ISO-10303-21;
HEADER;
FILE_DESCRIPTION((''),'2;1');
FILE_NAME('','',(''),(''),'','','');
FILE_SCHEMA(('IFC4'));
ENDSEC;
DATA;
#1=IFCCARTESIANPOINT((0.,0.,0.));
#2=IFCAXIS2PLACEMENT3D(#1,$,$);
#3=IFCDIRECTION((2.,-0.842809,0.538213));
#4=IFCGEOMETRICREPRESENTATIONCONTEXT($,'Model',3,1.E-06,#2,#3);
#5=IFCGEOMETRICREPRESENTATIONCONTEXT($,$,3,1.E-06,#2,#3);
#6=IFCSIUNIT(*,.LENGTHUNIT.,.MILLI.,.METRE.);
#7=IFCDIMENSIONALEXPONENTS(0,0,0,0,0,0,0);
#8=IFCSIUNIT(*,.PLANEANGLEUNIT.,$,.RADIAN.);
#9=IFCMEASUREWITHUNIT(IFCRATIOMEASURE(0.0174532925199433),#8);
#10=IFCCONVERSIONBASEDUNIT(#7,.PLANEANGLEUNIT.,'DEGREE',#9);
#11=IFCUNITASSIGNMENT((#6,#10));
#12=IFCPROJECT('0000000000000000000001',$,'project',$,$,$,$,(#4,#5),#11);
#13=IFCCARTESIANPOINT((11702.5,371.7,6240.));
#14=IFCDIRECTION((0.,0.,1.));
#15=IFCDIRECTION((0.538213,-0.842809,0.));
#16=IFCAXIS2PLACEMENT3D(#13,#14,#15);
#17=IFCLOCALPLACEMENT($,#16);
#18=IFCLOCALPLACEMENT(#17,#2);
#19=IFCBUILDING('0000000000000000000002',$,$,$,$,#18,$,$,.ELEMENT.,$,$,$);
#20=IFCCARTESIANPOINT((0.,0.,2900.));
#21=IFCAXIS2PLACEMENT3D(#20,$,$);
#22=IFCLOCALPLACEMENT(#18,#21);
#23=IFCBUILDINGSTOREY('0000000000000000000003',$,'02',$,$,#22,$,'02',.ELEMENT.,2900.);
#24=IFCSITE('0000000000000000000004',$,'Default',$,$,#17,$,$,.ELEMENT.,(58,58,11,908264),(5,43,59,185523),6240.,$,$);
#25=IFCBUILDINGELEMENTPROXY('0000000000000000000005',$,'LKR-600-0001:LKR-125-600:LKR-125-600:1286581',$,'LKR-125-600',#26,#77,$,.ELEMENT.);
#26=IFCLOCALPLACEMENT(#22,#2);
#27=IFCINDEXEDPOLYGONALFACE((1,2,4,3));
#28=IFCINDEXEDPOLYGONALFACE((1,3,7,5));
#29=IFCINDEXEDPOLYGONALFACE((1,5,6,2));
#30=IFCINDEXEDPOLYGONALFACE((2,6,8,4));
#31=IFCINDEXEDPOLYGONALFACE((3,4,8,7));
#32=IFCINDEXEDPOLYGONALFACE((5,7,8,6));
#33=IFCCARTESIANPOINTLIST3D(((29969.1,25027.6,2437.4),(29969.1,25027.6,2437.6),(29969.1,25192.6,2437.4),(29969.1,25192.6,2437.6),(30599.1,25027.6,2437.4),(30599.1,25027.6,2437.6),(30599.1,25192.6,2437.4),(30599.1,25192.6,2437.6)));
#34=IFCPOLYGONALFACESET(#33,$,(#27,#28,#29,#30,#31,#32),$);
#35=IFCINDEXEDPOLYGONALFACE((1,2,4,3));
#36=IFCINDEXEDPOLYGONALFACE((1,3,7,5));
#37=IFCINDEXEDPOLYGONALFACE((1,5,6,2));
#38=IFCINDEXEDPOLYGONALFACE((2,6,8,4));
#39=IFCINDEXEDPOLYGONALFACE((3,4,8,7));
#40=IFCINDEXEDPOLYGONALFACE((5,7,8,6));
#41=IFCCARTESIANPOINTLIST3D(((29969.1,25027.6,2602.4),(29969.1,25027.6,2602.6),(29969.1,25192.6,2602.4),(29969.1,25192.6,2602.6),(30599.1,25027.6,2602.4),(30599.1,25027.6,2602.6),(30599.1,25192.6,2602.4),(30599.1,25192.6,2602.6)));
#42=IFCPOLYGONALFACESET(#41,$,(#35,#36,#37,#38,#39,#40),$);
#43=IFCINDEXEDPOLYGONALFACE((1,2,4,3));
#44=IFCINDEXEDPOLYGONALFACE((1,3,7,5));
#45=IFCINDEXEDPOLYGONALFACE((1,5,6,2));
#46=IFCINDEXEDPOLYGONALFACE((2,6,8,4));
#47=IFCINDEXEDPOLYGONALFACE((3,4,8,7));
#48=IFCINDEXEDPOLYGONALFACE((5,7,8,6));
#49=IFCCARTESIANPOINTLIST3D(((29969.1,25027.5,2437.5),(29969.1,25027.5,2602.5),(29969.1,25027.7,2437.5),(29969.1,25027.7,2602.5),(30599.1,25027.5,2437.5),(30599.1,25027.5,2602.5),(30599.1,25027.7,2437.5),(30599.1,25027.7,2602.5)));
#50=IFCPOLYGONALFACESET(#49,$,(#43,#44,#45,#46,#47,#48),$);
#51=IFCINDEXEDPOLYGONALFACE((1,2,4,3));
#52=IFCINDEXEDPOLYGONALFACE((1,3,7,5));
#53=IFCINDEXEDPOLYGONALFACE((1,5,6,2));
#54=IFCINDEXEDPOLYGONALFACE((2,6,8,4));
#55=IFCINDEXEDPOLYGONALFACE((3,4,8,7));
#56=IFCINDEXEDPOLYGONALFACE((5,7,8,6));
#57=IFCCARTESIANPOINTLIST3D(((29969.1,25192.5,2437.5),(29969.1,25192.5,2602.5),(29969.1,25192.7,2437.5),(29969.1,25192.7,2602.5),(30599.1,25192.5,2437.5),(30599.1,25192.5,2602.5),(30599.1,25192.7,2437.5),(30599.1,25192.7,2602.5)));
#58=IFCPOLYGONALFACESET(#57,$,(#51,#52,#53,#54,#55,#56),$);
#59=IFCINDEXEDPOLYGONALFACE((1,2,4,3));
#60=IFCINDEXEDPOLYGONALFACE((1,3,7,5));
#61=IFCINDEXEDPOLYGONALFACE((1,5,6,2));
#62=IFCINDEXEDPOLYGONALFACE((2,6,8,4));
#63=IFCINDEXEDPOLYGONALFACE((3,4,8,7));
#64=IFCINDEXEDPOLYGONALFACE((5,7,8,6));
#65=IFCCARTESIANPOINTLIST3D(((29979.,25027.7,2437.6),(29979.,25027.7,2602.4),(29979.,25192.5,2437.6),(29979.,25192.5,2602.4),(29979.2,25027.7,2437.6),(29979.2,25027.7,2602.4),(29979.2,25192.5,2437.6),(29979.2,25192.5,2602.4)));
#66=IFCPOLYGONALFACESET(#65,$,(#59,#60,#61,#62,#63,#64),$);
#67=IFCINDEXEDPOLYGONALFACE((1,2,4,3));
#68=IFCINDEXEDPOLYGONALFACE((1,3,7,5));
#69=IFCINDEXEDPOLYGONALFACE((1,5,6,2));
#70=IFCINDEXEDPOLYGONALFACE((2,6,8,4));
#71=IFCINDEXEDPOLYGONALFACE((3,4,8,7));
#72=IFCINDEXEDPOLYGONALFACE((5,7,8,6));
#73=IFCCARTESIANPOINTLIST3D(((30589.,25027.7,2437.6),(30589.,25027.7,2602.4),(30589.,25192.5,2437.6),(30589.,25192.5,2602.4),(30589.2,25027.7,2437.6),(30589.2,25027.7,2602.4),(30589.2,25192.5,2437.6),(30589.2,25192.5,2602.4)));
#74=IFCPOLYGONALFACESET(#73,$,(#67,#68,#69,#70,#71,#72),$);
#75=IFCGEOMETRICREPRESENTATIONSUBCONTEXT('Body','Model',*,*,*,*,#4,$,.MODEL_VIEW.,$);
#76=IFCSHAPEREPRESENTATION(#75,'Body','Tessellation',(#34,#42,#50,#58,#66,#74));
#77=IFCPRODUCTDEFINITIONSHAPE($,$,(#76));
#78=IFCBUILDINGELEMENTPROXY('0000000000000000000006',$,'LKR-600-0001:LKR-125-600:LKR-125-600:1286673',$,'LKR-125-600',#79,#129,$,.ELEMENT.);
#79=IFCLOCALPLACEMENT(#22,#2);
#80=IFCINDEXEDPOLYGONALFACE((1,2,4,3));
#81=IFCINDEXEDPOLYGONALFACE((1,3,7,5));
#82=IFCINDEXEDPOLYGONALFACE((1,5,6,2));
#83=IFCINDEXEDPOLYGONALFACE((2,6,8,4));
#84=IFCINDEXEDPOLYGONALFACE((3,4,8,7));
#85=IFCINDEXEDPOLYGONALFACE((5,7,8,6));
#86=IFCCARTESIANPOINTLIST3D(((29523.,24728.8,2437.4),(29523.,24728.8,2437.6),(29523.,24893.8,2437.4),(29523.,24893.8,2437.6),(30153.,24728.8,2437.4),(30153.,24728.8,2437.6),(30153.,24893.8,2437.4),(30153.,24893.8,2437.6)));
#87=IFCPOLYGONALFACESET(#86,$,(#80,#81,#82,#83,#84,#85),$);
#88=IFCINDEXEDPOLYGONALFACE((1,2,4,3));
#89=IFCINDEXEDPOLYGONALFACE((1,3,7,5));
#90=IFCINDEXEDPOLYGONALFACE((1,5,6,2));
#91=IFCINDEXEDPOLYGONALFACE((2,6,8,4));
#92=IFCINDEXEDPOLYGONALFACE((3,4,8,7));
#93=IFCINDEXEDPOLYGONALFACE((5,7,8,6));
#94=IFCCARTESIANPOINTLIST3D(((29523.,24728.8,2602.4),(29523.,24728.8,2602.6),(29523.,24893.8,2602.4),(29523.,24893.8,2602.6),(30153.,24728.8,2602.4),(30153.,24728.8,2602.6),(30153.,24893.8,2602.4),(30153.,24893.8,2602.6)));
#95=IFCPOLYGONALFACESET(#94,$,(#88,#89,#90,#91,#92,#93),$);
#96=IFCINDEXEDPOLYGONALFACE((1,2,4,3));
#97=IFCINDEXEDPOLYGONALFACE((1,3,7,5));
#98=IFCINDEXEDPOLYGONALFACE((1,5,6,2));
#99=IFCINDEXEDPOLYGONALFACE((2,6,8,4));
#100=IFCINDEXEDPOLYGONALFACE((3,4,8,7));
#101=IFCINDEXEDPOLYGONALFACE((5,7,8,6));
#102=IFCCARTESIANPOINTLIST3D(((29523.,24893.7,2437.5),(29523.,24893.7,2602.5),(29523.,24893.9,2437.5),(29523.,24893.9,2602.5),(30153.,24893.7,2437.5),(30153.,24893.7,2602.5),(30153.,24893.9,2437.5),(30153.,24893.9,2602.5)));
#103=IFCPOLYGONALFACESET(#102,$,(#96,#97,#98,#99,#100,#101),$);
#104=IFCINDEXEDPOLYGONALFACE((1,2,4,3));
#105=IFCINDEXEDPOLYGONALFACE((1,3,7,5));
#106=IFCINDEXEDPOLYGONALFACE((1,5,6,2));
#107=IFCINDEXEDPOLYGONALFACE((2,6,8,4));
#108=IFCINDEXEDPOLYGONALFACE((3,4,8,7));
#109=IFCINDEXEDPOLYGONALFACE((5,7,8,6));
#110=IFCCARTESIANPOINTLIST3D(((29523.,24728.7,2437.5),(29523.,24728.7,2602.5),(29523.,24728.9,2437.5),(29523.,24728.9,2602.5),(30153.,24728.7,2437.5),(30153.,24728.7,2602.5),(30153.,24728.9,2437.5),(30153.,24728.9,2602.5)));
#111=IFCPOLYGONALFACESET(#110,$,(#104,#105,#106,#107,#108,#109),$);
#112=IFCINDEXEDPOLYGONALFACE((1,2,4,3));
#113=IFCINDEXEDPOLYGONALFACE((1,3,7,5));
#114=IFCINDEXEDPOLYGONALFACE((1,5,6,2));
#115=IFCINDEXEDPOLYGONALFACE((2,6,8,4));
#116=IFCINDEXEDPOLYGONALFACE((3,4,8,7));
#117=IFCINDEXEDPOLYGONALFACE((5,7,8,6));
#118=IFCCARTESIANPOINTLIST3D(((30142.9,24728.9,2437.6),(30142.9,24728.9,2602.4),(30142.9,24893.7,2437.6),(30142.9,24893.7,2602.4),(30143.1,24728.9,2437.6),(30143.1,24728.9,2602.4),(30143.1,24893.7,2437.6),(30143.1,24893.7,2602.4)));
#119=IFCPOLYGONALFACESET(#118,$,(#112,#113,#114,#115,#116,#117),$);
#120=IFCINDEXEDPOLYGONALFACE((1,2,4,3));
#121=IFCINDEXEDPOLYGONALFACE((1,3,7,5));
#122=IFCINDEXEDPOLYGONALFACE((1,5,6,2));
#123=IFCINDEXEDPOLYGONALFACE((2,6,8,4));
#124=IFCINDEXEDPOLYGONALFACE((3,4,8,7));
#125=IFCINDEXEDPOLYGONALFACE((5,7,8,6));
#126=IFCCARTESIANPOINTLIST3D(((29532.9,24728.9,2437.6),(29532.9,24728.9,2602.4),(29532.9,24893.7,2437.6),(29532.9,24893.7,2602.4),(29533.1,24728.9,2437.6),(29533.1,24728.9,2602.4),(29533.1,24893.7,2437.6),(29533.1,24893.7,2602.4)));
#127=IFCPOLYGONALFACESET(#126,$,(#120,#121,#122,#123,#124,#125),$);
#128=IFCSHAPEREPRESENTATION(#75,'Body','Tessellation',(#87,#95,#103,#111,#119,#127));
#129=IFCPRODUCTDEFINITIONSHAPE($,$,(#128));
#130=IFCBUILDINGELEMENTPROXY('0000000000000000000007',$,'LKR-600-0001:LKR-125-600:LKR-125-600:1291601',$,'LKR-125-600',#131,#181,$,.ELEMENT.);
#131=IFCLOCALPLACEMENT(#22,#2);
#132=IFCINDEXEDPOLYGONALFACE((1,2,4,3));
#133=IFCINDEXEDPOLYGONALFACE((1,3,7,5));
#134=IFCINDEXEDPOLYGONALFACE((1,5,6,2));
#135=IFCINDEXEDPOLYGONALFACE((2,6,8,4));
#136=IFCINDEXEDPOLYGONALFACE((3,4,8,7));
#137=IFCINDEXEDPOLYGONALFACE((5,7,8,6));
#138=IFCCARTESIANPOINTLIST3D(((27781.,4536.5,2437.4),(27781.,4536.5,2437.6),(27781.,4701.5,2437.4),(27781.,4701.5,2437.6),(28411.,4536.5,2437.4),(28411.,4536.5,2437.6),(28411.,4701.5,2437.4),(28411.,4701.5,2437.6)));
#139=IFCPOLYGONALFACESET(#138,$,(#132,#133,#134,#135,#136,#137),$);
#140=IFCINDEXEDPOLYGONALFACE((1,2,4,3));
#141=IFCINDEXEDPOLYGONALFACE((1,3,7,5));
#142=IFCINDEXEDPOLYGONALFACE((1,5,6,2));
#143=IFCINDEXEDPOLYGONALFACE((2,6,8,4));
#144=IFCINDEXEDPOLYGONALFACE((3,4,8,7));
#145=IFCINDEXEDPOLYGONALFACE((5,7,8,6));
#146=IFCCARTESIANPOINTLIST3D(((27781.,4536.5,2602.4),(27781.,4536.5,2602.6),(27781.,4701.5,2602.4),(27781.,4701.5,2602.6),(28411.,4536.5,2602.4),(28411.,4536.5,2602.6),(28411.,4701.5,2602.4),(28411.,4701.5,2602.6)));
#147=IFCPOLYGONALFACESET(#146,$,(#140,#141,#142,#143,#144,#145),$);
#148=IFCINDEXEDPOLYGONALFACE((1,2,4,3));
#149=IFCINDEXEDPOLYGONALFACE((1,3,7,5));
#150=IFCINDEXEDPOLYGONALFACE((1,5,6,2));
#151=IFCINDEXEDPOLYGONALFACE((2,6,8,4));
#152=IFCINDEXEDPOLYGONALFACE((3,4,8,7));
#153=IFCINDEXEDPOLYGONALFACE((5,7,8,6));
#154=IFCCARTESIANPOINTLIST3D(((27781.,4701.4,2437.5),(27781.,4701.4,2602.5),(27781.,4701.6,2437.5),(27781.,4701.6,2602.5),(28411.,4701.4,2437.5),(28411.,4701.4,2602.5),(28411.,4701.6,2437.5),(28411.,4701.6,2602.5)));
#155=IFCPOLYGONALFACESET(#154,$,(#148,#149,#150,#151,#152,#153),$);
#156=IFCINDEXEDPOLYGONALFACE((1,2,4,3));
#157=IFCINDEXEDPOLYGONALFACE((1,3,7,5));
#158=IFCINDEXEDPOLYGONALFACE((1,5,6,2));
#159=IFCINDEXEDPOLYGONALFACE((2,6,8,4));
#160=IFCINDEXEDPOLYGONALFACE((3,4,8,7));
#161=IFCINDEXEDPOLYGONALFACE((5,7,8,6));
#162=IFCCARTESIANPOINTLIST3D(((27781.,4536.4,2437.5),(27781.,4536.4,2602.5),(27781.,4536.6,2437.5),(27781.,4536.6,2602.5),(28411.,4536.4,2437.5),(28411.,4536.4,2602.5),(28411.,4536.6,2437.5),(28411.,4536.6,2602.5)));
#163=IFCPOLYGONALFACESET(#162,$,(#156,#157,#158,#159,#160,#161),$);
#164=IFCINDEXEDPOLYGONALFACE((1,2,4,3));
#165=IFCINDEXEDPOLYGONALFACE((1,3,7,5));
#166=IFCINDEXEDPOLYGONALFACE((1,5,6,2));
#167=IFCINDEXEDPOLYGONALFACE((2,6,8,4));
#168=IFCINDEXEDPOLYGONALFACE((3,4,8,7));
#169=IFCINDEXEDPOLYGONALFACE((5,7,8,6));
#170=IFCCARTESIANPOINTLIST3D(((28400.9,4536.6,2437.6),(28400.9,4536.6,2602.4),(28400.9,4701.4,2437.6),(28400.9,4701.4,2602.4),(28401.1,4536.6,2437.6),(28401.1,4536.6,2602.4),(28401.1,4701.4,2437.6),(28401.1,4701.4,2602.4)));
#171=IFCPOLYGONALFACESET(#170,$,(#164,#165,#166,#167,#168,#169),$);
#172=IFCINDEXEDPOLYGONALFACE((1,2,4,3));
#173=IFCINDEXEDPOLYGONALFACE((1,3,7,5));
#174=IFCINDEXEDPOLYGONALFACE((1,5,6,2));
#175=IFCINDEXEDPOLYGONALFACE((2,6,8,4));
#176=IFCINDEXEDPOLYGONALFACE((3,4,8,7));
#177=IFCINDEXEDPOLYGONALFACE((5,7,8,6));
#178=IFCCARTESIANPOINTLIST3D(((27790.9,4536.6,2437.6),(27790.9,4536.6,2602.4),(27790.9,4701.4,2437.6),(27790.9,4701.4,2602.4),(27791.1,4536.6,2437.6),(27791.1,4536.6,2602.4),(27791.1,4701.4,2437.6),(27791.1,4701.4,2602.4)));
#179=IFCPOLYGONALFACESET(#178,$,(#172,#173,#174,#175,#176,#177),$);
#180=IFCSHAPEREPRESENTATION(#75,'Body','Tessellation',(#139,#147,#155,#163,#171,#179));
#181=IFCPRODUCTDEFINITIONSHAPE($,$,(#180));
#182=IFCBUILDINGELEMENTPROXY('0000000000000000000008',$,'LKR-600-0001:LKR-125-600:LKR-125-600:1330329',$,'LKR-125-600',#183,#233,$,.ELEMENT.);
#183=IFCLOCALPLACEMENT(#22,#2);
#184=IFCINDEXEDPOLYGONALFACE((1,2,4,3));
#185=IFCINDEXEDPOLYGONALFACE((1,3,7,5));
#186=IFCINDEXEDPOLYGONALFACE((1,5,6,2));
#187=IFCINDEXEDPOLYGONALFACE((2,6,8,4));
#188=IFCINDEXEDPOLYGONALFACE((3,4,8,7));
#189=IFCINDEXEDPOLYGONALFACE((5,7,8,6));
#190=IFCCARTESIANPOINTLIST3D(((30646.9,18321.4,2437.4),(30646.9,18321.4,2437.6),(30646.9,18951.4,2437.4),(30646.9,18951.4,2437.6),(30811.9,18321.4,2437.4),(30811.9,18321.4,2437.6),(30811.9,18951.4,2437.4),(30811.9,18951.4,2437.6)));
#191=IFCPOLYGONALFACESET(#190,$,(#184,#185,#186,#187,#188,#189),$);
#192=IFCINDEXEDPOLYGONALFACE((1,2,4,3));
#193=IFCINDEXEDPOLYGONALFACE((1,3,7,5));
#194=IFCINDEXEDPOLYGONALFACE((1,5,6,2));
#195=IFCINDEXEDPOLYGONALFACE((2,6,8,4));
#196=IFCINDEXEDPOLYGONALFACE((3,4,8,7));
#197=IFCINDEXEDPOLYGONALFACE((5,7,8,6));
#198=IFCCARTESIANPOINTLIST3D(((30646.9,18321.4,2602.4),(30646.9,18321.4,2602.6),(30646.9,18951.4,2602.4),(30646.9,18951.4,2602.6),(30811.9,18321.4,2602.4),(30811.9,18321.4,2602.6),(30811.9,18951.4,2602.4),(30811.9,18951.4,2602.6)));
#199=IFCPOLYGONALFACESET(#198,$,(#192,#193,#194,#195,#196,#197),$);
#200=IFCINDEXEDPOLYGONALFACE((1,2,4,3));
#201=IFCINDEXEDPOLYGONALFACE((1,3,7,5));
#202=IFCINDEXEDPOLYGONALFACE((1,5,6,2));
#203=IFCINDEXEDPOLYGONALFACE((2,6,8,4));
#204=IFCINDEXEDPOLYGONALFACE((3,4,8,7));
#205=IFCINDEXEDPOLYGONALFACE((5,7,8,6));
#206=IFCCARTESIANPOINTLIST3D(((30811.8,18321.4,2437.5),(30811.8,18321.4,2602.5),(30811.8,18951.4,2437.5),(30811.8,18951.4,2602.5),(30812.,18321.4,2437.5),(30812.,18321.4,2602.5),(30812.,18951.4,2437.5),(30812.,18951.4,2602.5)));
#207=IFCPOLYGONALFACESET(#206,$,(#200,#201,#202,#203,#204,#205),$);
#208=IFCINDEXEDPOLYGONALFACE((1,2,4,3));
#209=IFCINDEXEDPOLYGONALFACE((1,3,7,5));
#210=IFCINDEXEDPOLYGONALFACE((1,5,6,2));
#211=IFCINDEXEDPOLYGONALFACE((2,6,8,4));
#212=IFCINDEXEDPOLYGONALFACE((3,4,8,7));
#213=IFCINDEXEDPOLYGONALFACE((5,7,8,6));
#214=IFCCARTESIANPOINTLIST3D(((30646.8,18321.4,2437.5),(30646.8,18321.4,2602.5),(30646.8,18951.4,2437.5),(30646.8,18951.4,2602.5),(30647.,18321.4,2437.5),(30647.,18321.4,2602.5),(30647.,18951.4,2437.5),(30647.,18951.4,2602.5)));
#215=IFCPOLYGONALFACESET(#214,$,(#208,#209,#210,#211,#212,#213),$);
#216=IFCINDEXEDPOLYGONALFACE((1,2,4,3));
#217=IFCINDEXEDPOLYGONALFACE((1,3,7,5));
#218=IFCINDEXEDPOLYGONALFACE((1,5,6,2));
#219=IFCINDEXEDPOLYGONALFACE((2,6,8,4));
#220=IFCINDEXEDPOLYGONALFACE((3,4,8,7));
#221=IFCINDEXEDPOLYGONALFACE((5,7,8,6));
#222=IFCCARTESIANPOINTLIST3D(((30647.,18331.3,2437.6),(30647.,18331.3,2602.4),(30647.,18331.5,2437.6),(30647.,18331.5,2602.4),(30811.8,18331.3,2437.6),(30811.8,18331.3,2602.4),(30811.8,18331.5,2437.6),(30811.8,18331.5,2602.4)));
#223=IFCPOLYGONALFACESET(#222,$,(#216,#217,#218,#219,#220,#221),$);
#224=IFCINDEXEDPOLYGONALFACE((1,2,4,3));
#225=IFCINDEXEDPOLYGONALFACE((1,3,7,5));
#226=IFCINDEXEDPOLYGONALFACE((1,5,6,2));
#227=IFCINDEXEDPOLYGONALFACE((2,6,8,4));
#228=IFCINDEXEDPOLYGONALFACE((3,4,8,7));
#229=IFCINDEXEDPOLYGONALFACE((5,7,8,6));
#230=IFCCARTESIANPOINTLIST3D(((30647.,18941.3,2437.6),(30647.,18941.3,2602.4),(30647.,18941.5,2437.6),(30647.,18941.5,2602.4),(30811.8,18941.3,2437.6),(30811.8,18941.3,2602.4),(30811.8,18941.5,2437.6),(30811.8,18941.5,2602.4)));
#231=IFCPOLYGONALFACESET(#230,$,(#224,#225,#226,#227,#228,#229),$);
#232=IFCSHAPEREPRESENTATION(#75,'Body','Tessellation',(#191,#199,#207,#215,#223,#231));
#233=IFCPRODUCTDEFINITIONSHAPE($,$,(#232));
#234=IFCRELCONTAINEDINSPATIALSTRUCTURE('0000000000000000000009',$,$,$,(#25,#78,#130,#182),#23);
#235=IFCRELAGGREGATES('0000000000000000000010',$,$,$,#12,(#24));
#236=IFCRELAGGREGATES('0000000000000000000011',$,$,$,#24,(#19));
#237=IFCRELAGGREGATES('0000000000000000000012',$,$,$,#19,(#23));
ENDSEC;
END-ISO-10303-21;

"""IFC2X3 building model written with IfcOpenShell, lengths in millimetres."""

from ifc_helpers import new_model, entity, si_unit, converted_unit, direction, frame, frame_2d, origin, place, context, subcontext, project, spatial, rectangle, extrude, source, transform, mapped, element, save


model = new_model("IFC2X3")

# Units and contexts
model_context = context("Model", 3, precision=1e-06, world=origin(), true_north=direction((2.0, -0.842809, 0.538213)))
context_of_model = context(None, 3, precision=1e-06, world=origin(), true_north=direction((2.0, -0.842809, 0.538213)))
body_context = subcontext(model_context, "Body", "Model", "MODEL_VIEW")
ifc_project = project(units=[si_unit("LENGTHUNIT", "METRE", prefix="MILLI"), converted_unit("PLANEANGLEUNIT", "DEGREE", entity("IfcRatioMeasure", 0.0174532925199433), si_unit("PLANEANGLEUNIT", "RADIAN"), dimensions=[0, 0, 0, 0, 0, 0, 0])], contexts=[model_context, context_of_model])

# Site, building, storey
site_placement = place(None, frame((11702.5, 371.7, 6240.0), z_axis=(0.0, 0.0, 1.0), x_axis=(0.538213, -0.842809, 0.0)))
site = spatial("IfcSite", under=ifc_project, at=site_placement, Name="Default", CompositionType="ELEMENT", RefLatitude=(58, 58, 11, 908264), RefLongitude=(5, 43, 59, 185523), RefElevation=6240.0)
building_placement = place(site_placement, origin())
building = spatial("IfcBuilding", under=site, at=building_placement, CompositionType="ELEMENT")
storey_placement = place(building_placement, frame((0.0, 0.0, 2900.0)))
storey = spatial("IfcBuildingStorey", under=building, at=storey_placement, Name="02", LongName="02", CompositionType="ELEMENT", Elevation=2900.0)

# Building element proxies
shared_shape_1 = source(origin(), body_context, "Body", "SweptSolid", [
    extrude(rectangle(XDim=165.0, YDim=630.0, at=frame_2d((0.0, 0.0), x_axis=(1.0, 0.0))), frame((0.0, 0.0, -82.6), z_axis=(0.0, 0.0, 1.0), x_axis=(0.0, -1.0, 0.0)), (0.0, 0.0, 1.0), 0.2),
    extrude(rectangle(XDim=165.0, YDim=630.0, at=frame_2d((0.0, 0.0), x_axis=(1.0, 0.0))), frame((0.0, 0.0, 82.4), z_axis=(0.0, 0.0, 1.0), x_axis=(0.0, -1.0, 0.0)), (0.0, 0.0, 1.0), 0.2),
    extrude(rectangle(XDim=0.2, YDim=630.0, at=frame_2d((0.0, 0.0), x_axis=(1.0, 0.0))), frame((0.0, 82.5, -82.5), z_axis=(0.0, 0.0, 1.0), x_axis=(0.0, 1.0, 0.0)), (0.0, 0.0, 1.0), 165.0),
    extrude(rectangle(XDim=0.2, YDim=630.0, at=frame_2d((0.0, 0.0), x_axis=(1.0, 0.0))), frame((0.0, -82.5, -82.5), z_axis=(0.0, 0.0, 1.0), x_axis=(0.0, 1.0, 0.0)), (0.0, 0.0, 1.0), 165.0),
    extrude(rectangle(XDim=0.2, YDim=164.8, at=frame_2d((0.0, 0.0), x_axis=(1.0, 0.0))), frame((305.0, 0.0, -82.4)), (0.0, 0.0, 1.0), 164.8),
    extrude(rectangle(XDim=0.2, YDim=164.8, at=frame_2d((0.0, 0.0), x_axis=(1.0, 0.0))), frame((-305.0, 0.0, -82.4)), (0.0, 0.0, 1.0), 164.8),
])
for number, where, z_axis, x_axis, name in (
    (1, (30284.1, 25110.1, 2520.0), (0.0, 0.0, 1.0), (-1.0, 0.0, 0.0), "LKR-600-0001:LKR-125-600:LKR-125-600:1286581"),
):
    element("IfcBuildingElementProxy", number, at=place(storey_placement, frame(where, z_axis=z_axis, x_axis=x_axis)), inside=storey, Name=name, ObjectType="LKR-125-600", CompositionType="ELEMENT", context=body_context, shape_type="MappedRepresentation", body=[
        mapped(shared_shape_1, transform((0.0, 0.0, 0.0), scale=1.0)),
    ])
for number, where, name in (
    (2, (29838.0, 24811.3, 2520.0), "LKR-600-0001:LKR-125-600:LKR-125-600:1286673"),
    (3, (28096.0, 4619.0, 2520.0), "LKR-600-0001:LKR-125-600:LKR-125-600:1291601"),
):
    element("IfcBuildingElementProxy", number, at=place(storey_placement, frame(where)), inside=storey, Name=name, ObjectType="LKR-125-600", CompositionType="ELEMENT", context=body_context, shape_type="MappedRepresentation", body=[
        mapped(shared_shape_1, transform((0.0, 0.0, 0.0), scale=1.0)),
    ])
for number, where, z_axis, x_axis, name in (
    (4, (30729.4, 18636.4, 2520.0), (0.0, 0.0, 1.0), (0.0, -1.0, 0.0), "LKR-600-0001:LKR-125-600:LKR-125-600:1330329"),
):
    element("IfcBuildingElementProxy", number, at=place(storey_placement, frame(where, z_axis=z_axis, x_axis=x_axis)), inside=storey, Name=name, ObjectType="LKR-125-600", CompositionType="ELEMENT", context=body_context, shape_type="MappedRepresentation", body=[
        mapped(shared_shape_1, transform((0.0, 0.0, 0.0), scale=1.0)),
    ])

save(model, "model.ifc")
